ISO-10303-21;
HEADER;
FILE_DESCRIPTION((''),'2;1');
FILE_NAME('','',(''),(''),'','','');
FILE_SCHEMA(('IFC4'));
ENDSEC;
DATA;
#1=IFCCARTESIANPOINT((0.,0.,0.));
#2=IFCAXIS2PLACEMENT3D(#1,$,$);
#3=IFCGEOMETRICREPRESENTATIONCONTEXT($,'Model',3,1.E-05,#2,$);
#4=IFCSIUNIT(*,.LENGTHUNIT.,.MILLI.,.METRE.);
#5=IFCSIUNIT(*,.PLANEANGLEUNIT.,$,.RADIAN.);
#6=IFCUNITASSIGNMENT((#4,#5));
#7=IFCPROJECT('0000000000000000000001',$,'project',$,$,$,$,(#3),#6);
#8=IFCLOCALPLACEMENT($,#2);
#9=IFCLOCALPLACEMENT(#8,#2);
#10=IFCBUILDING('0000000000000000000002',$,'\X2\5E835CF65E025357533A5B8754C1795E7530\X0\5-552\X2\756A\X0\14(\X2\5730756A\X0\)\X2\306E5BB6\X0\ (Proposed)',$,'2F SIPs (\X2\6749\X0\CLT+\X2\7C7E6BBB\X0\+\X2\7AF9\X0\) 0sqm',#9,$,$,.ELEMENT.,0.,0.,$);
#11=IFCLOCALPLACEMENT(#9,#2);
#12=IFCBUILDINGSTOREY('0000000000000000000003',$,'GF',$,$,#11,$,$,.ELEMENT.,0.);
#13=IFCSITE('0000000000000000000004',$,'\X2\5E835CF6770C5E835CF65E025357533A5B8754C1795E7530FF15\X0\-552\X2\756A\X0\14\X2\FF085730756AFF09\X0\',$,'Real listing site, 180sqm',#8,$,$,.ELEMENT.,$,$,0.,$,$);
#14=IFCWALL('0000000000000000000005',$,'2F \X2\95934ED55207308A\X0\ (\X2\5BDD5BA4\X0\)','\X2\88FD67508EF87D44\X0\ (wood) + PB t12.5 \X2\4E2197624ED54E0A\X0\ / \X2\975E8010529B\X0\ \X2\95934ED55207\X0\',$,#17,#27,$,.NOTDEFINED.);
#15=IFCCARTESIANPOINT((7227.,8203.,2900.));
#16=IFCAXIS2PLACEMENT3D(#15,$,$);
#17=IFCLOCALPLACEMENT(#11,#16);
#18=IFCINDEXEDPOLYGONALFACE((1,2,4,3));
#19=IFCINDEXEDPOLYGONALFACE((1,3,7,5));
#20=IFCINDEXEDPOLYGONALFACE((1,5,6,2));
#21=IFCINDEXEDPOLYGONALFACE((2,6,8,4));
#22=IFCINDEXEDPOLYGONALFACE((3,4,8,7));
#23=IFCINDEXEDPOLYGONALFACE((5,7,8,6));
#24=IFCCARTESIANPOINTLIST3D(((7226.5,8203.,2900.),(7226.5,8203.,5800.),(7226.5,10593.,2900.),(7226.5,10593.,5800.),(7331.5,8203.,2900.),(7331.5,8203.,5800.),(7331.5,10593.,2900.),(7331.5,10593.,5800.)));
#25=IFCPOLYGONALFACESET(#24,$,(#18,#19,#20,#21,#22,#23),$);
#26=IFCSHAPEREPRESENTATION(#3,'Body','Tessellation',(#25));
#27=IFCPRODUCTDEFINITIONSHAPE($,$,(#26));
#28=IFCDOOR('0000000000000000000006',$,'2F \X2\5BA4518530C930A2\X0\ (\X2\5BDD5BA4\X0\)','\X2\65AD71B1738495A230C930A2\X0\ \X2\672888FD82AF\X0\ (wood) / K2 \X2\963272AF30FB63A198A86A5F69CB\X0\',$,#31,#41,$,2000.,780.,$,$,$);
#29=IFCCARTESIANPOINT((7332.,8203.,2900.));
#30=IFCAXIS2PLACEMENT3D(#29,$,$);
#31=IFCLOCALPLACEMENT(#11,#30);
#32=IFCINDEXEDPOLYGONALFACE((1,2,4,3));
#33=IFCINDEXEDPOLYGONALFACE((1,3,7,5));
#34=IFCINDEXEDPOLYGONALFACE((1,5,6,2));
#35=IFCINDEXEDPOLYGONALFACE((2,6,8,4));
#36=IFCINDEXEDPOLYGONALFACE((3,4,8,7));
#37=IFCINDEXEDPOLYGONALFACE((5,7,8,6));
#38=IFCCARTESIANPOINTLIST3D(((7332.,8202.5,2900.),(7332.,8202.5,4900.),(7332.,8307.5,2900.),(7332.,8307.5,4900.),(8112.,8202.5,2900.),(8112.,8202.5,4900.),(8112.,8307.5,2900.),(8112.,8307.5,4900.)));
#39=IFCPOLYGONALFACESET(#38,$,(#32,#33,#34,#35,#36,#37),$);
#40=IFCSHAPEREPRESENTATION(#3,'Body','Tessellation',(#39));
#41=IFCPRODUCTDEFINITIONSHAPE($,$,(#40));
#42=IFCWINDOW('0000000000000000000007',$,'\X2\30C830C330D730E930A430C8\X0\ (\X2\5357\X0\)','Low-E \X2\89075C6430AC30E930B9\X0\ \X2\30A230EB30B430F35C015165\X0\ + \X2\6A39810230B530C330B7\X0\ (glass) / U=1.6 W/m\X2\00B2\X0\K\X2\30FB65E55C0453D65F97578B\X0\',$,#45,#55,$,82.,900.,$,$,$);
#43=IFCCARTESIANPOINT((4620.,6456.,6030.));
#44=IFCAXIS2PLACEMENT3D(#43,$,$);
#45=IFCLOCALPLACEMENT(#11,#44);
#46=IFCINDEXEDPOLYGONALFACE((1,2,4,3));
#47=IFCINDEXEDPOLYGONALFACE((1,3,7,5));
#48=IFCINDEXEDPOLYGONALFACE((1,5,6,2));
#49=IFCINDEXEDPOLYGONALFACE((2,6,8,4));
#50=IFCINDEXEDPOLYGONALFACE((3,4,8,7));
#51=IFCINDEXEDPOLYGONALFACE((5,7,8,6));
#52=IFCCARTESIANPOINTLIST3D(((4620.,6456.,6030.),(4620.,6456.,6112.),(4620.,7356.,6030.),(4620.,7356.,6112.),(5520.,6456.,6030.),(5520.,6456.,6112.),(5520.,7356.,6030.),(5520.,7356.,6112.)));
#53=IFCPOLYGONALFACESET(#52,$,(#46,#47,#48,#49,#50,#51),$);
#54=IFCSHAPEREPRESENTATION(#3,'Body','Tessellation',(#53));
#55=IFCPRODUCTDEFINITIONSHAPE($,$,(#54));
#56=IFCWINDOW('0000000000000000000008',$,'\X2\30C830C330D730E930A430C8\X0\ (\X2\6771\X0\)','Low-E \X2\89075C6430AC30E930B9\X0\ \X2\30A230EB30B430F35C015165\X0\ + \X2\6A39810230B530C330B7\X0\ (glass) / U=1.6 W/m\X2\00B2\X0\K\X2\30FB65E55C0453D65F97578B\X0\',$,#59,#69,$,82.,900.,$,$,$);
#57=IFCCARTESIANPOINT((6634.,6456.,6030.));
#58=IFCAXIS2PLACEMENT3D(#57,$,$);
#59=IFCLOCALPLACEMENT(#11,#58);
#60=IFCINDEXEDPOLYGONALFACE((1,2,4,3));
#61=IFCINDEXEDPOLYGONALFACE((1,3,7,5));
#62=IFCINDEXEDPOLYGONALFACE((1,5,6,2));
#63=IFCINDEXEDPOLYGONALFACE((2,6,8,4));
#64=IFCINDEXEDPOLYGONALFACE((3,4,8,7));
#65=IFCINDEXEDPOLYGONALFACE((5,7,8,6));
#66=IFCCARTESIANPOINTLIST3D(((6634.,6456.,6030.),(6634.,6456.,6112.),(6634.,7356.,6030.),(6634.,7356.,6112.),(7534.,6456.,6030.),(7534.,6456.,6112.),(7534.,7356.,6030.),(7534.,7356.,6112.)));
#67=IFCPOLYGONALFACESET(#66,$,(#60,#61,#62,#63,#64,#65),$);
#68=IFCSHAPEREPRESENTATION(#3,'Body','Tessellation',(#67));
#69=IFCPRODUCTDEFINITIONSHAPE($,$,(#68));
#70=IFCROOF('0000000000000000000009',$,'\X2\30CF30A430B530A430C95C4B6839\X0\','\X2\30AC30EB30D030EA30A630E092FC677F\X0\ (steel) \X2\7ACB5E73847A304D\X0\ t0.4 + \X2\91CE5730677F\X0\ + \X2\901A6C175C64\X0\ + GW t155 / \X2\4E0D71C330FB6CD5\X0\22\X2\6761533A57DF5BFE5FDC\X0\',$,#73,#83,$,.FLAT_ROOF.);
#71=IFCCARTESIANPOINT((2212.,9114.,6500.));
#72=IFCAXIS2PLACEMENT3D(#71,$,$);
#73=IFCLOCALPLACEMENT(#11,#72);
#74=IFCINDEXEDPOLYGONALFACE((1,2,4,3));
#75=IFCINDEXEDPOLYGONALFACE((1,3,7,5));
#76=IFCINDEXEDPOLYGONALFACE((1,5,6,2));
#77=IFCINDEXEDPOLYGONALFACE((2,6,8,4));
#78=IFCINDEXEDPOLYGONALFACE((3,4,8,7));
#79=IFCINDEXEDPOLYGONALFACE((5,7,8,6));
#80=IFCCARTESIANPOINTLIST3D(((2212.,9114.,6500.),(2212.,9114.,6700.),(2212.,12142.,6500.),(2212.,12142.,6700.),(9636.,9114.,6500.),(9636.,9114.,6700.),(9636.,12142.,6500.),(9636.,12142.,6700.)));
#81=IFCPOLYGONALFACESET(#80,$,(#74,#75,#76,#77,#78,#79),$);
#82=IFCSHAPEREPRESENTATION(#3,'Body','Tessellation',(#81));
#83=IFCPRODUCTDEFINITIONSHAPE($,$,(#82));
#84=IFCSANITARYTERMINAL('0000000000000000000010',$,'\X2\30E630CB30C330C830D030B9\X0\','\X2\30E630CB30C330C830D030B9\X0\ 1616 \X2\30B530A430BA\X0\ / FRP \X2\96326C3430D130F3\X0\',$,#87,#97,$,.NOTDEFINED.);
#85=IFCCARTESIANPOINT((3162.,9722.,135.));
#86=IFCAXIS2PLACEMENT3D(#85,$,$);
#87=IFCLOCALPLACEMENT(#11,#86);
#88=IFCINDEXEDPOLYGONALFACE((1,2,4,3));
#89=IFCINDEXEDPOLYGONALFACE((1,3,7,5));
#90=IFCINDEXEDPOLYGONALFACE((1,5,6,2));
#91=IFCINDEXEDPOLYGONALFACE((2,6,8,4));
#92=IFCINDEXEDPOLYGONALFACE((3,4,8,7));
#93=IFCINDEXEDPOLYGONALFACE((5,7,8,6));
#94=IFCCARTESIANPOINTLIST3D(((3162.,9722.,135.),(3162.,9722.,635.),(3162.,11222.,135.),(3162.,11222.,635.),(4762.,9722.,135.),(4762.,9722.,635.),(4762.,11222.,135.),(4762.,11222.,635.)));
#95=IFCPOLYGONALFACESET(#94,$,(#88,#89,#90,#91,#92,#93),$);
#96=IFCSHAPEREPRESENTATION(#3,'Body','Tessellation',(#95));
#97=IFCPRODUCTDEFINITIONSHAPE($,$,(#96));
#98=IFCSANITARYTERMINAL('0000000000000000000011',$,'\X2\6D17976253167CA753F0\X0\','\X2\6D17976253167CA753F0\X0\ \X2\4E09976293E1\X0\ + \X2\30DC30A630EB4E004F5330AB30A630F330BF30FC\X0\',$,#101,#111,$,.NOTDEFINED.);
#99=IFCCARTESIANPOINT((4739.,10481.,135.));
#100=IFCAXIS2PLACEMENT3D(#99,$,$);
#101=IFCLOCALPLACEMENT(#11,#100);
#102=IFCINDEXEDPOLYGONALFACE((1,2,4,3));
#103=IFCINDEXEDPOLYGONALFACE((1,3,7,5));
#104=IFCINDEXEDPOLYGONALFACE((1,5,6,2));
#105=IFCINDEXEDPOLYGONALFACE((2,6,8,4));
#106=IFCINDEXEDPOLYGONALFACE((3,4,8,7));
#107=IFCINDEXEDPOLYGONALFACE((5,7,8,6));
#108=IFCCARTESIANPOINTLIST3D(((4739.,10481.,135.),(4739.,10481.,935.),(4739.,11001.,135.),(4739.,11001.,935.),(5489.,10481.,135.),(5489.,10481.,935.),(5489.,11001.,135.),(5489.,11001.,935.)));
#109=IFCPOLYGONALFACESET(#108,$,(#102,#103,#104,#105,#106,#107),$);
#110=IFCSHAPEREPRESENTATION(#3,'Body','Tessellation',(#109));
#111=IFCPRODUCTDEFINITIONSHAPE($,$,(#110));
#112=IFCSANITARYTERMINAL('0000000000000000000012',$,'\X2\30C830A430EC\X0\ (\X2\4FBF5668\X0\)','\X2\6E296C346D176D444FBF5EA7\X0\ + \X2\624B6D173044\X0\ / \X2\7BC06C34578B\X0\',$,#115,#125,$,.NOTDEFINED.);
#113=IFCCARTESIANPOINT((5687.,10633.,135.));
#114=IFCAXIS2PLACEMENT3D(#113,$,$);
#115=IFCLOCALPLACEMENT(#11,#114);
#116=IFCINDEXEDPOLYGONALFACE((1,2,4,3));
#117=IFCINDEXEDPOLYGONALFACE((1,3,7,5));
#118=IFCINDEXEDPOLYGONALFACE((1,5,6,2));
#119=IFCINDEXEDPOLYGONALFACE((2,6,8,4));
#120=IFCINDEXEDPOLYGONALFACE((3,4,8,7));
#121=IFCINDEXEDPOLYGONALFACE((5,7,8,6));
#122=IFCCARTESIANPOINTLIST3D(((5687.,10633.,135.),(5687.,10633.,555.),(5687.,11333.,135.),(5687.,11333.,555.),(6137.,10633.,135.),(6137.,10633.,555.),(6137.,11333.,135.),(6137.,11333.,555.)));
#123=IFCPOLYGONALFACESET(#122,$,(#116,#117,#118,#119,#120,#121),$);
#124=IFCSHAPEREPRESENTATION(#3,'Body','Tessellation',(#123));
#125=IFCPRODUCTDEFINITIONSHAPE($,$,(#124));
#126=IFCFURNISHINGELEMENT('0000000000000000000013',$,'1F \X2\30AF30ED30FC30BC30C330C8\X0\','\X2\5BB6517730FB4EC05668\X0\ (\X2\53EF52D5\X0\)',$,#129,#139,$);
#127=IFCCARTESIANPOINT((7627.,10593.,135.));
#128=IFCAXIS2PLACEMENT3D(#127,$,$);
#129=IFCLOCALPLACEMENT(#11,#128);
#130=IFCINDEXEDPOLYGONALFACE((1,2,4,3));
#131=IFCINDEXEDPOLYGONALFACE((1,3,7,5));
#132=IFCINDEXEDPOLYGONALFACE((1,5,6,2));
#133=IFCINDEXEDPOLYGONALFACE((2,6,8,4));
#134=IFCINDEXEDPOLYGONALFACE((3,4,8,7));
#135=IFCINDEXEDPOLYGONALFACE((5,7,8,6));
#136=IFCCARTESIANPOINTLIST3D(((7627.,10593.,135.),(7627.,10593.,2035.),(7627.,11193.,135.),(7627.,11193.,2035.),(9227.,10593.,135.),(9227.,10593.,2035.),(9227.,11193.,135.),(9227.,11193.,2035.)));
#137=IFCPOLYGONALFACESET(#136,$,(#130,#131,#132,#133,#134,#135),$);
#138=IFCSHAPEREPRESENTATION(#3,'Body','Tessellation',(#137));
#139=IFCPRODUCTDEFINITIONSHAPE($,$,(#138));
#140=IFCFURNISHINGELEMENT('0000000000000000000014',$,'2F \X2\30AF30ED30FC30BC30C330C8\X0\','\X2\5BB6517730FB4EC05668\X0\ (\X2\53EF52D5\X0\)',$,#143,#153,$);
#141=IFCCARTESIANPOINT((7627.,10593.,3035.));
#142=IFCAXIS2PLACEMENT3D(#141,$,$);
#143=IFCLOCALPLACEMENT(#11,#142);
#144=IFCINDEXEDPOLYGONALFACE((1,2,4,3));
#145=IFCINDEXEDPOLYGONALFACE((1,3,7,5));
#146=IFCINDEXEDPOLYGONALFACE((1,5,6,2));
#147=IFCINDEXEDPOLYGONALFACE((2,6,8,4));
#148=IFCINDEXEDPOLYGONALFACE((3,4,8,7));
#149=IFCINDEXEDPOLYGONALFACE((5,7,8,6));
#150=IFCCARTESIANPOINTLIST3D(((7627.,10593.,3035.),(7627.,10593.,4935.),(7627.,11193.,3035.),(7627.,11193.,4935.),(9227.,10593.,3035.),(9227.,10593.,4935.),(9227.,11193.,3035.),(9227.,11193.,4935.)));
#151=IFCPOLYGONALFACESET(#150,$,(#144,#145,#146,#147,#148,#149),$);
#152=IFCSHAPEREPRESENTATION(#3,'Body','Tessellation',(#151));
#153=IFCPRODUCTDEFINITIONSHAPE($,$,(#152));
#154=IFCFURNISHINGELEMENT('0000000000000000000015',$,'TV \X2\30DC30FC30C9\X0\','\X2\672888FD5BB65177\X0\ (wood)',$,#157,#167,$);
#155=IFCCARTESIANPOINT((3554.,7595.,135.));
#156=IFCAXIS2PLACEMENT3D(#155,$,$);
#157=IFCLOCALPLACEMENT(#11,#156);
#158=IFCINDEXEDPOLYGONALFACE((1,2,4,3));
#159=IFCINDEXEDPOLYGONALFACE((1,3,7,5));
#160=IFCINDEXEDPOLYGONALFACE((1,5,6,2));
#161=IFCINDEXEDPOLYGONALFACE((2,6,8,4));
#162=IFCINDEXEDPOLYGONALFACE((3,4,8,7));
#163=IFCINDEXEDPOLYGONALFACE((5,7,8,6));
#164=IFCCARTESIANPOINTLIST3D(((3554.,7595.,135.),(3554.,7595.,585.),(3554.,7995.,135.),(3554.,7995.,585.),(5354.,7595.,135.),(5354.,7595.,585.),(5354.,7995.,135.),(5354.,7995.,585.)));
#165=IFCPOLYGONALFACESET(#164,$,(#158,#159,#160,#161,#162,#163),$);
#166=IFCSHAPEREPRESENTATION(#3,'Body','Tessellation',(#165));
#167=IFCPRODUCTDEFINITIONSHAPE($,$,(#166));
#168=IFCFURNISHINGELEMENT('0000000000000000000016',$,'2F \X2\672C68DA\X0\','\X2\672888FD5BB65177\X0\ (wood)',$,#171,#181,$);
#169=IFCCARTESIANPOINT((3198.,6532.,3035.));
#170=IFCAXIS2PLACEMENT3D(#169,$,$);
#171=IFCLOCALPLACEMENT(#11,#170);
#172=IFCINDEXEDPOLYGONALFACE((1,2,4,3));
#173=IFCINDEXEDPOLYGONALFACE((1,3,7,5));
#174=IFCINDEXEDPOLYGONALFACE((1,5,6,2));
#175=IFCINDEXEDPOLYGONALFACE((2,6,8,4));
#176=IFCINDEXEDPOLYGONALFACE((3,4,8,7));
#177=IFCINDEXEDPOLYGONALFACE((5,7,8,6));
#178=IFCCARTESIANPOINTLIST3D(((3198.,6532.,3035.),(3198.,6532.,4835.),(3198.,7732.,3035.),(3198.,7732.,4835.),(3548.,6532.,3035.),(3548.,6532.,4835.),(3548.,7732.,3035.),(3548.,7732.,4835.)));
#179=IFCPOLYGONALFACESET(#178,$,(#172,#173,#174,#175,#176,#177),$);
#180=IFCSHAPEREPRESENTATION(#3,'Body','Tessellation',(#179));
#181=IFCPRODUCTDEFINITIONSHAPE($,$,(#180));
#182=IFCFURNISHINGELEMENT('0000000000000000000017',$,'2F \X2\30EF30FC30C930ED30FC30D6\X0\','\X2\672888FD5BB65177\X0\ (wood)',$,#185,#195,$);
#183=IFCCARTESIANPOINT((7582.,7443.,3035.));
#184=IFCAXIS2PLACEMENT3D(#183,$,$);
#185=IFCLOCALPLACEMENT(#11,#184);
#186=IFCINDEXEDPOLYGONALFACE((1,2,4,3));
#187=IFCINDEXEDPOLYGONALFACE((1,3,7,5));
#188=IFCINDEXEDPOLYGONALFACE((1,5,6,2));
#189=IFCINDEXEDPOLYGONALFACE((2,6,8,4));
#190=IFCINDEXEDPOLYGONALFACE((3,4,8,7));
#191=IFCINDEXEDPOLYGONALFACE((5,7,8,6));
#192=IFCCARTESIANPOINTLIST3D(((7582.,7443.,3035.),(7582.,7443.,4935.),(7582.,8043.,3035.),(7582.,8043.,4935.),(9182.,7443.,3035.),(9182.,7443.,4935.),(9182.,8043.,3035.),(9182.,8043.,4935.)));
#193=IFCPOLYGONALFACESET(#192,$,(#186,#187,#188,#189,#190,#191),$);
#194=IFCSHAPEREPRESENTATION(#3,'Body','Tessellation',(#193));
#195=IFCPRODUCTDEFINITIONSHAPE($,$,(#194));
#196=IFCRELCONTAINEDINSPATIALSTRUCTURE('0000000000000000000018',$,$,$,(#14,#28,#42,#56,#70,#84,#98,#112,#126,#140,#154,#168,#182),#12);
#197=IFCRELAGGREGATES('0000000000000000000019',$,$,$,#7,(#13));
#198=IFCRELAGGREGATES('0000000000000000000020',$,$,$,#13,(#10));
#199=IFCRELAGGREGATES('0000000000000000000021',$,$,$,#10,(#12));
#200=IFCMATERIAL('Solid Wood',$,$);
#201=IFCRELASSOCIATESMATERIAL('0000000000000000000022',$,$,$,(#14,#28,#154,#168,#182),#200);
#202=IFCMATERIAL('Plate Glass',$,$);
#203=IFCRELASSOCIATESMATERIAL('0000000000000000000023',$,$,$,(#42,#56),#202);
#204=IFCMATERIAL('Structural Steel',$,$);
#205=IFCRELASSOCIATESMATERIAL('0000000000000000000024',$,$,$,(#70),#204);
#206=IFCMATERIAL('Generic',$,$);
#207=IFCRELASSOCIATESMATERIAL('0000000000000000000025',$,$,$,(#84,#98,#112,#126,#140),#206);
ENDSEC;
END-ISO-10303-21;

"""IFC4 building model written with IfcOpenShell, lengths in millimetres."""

from ifc_helpers import new_model, si_unit, frame, frame_2d, origin, place, context, project, spatial, rectangle, extrude, material, element, save


model = new_model("IFC4")

# Units and contexts
model_context = context("Model", 3, precision=1e-05, world=origin())
ifc_project = project(units=[si_unit("LENGTHUNIT", "METRE", prefix="MILLI"), si_unit("PLANEANGLEUNIT", "RADIAN")], contexts=[model_context])

# Site, building, storey
site_placement = place(None, origin())
site = spatial("IfcSite", under=ifc_project, at=site_placement, Name="広島県広島市南区宇品神田５-552番14（地番）", ObjectType="Real listing site, 180sqm", CompositionType="ELEMENT", RefElevation=0.0)
building_placement = place(site_placement, origin())
building = spatial("IfcBuilding", under=site, at=building_placement, Name="広島市南区宇品神田5-552番14(地番)の家 (Proposed)", ObjectType="2F SIPs (杉CLT+籾殻+竹) 0sqm", CompositionType="ELEMENT", ElevationOfRefHeight=0.0, ElevationOfTerrain=0.0)
storey_placement = place(building_placement, origin())
storey = spatial("IfcBuildingStorey", under=building, at=storey_placement, Name="GF", CompositionType="ELEMENT", Elevation=0.0)

# Shared definitions
ifc_material_1 = material(Name="Solid Wood")
ifc_material_2 = material(Name="Plate Glass")

# Wall
wall_1_placement = place(storey_placement, frame((7227.0, 8203.0, 2900.0)))
element("IfcWall", 1, at=wall_1_placement, inside=storey, material=ifc_material_1, Name="2F 間仕切り (寝室)", Description="製材軸組 (wood) + PB t12.5 両面仕上 / 非耐力 間仕切", PredefinedType="NOTDEFINED", context=model_context, shape_type="SweptSolid", body=[
    extrude(rectangle(XDim=105.0, YDim=2390.0, at=frame_2d((52.0, 1195.0))), frame((7227.0, 8203.0, 2900.0)), (0.0, 0.0, 1.0), 2900.0),
])

# Door
door_1_placement = place(storey_placement, frame((7332.0, 8203.0, 2900.0)))
element("IfcDoor", 2, at=door_1_placement, inside=storey, material=ifc_material_1, Name="2F 室内ドア (寝室)", Description="断熱玄関ドア 木製芯 (wood) / K2 防犯・採風機構", OverallHeight=2000.0, OverallWidth=780.0, context=model_context, shape_type="SweptSolid", body=[
    extrude(rectangle(XDim=780.0, YDim=105.0, at=frame_2d((390.0, 52.0))), frame((7332.0, 8203.0, 2900.0)), (0.0, 0.0, 1.0), 2000.0),
])

# Windows
window_1_placement = place(storey_placement, frame((4620.0, 6456.0, 6030.0)))
element("IfcWindow", 3, at=window_1_placement, inside=storey, material=ifc_material_2, Name="トップライト (南)", Description="Low-E 複層ガラス アルゴン封入 + 樹脂サッシ (glass) / U=1.6 W/m²K・日射取得型", OverallHeight=82.0, OverallWidth=900.0, context=model_context, shape_type="SweptSolid", body=[
    extrude(rectangle(XDim=900.0, YDim=900.0, at=frame_2d((450.0, 450.0))), frame((4620.0, 6456.0, 6030.0)), (0.0, 0.0, 1.0), 82.0),
])
window_2_placement = place(storey_placement, frame((6634.0, 6456.0, 6030.0)))
element("IfcWindow", 4, at=window_2_placement, inside=storey, material=ifc_material_2, Name="トップライト (東)", Description="Low-E 複層ガラス アルゴン封入 + 樹脂サッシ (glass) / U=1.6 W/m²K・日射取得型", OverallHeight=82.0, OverallWidth=900.0, context=model_context, shape_type="SweptSolid", body=[
    extrude(rectangle(XDim=900.0, YDim=900.0, at=frame_2d((450.0, 450.0))), frame((6634.0, 6456.0, 6030.0)), (0.0, 0.0, 1.0), 82.0),
])

# Roof
ifc_material_3 = material(Name="Structural Steel")
roof_placement = place(storey_placement, frame((2212.0, 9114.0, 6500.0)))
element("IfcRoof", 5, at=roof_placement, inside=storey, material=ifc_material_3, Name="ハイサイド屋根", Description="ガルバリウム鋼板 (steel) 立平葺き t0.4 + 野地板 + 通気層 + GW t155 / 不燃・法22条区域対応", PredefinedType="FLAT_ROOF", context=model_context, shape_type="SweptSolid", body=[
    extrude(rectangle(XDim=7424.0, YDim=3028.0, at=frame_2d((3712.0, 1514.0))), frame((2212.0, 9114.0, 6500.0)), (0.0, 0.0, 1.0), 200.0),
])

# Sanitary terminals
ifc_material_4 = material(Name="Generic")
sanitary_terminal_1_placement = place(storey_placement, frame((3162.0, 9722.0, 135.0)))
element("IfcSanitaryTerminal", 6, at=sanitary_terminal_1_placement, inside=storey, material=ifc_material_4, Name="ユニットバス", Description="ユニットバス 1616 サイズ / FRP 防水パン", PredefinedType="NOTDEFINED", context=model_context, shape_type="SweptSolid", body=[
    extrude(rectangle(XDim=1600.0, YDim=1500.0, at=frame_2d((800.0, 750.0))), frame((3162.0, 9722.0, 135.0)), (0.0, 0.0, 1.0), 500.0),
])
sanitary_terminal_2_placement = place(storey_placement, frame((4739.0, 10481.0, 135.0)))
element("IfcSanitaryTerminal", 7, at=sanitary_terminal_2_placement, inside=storey, material=ifc_material_4, Name="洗面化粧台", Description="洗面化粧台 三面鏡 + ボウル一体カウンター", PredefinedType="NOTDEFINED", context=model_context, shape_type="SweptSolid", body=[
    extrude(rectangle(XDim=750.0, YDim=520.0, at=frame_2d((375.0, 260.0))), frame((4739.0, 10481.0, 135.0)), (0.0, 0.0, 1.0), 800.0),
])
sanitary_terminal_3_placement = place(storey_placement, frame((5687.0, 10633.0, 135.0)))
element("IfcSanitaryTerminal", 8, at=sanitary_terminal_3_placement, inside=storey, material=ifc_material_4, Name="トイレ (便器)", Description="温水洗浄便座 + 手洗い / 節水型", PredefinedType="NOTDEFINED", context=model_context, shape_type="SweptSolid", body=[
    extrude(rectangle(XDim=450.0, YDim=700.0, at=frame_2d((225.0, 350.0))), frame((5687.0, 10633.0, 135.0)), (0.0, 0.0, 1.0), 420.0),
])

# Furnishing elements
furnishing_1_placement = place(storey_placement, frame((7627.0, 10593.0, 135.0)))
element("IfcFurnishingElement", 9, at=furnishing_1_placement, inside=storey, material=ifc_material_4, Name="1F クローゼット", Description="家具・什器 (可動)", context=model_context, shape_type="SweptSolid", body=[
    extrude(rectangle(XDim=1600.0, YDim=600.0, at=frame_2d((800.0, 300.0))), frame((7627.0, 10593.0, 135.0)), (0.0, 0.0, 1.0), 1900.0),
])
furnishing_2_placement = place(storey_placement, frame((7627.0, 10593.0, 3035.0)))
element("IfcFurnishingElement", 10, at=furnishing_2_placement, inside=storey, material=ifc_material_4, Name="2F クローゼット", Description="家具・什器 (可動)", context=model_context, shape_type="SweptSolid", body=[
    extrude(rectangle(XDim=1600.0, YDim=600.0, at=frame_2d((800.0, 300.0))), frame((7627.0, 10593.0, 3035.0)), (0.0, 0.0, 1.0), 1900.0),
])
furnishing_3_placement = place(storey_placement, frame((3554.0, 7595.0, 135.0)))
element("IfcFurnishingElement", 11, at=furnishing_3_placement, inside=storey, material=ifc_material_1, Name="TV ボード", Description="木製家具 (wood)", context=model_context, shape_type="SweptSolid", body=[
    extrude(rectangle(XDim=1800.0, YDim=400.0, at=frame_2d((900.0, 200.0))), frame((3554.0, 7595.0, 135.0)), (0.0, 0.0, 1.0), 450.0),
])
furnishing_4_placement = place(storey_placement, frame((3198.0, 6532.0, 3035.0)))
element("IfcFurnishingElement", 12, at=furnishing_4_placement, inside=storey, material=ifc_material_1, Name="2F 本棚", Description="木製家具 (wood)", context=model_context, shape_type="SweptSolid", body=[
    extrude(rectangle(XDim=350.0, YDim=1200.0, at=frame_2d((175.0, 600.0))), frame((3198.0, 6532.0, 3035.0)), (0.0, 0.0, 1.0), 1800.0),
])
furnishing_5_placement = place(storey_placement, frame((7582.0, 7443.0, 3035.0)))
element("IfcFurnishingElement", 13, at=furnishing_5_placement, inside=storey, material=ifc_material_1, Name="2F ワードローブ", Description="木製家具 (wood)", context=model_context, shape_type="SweptSolid", body=[
    extrude(rectangle(XDim=1600.0, YDim=600.0, at=frame_2d((800.0, 300.0))), frame((7582.0, 7443.0, 3035.0)), (0.0, 0.0, 1.0), 1900.0),
])

save(model, "model.ifc")
